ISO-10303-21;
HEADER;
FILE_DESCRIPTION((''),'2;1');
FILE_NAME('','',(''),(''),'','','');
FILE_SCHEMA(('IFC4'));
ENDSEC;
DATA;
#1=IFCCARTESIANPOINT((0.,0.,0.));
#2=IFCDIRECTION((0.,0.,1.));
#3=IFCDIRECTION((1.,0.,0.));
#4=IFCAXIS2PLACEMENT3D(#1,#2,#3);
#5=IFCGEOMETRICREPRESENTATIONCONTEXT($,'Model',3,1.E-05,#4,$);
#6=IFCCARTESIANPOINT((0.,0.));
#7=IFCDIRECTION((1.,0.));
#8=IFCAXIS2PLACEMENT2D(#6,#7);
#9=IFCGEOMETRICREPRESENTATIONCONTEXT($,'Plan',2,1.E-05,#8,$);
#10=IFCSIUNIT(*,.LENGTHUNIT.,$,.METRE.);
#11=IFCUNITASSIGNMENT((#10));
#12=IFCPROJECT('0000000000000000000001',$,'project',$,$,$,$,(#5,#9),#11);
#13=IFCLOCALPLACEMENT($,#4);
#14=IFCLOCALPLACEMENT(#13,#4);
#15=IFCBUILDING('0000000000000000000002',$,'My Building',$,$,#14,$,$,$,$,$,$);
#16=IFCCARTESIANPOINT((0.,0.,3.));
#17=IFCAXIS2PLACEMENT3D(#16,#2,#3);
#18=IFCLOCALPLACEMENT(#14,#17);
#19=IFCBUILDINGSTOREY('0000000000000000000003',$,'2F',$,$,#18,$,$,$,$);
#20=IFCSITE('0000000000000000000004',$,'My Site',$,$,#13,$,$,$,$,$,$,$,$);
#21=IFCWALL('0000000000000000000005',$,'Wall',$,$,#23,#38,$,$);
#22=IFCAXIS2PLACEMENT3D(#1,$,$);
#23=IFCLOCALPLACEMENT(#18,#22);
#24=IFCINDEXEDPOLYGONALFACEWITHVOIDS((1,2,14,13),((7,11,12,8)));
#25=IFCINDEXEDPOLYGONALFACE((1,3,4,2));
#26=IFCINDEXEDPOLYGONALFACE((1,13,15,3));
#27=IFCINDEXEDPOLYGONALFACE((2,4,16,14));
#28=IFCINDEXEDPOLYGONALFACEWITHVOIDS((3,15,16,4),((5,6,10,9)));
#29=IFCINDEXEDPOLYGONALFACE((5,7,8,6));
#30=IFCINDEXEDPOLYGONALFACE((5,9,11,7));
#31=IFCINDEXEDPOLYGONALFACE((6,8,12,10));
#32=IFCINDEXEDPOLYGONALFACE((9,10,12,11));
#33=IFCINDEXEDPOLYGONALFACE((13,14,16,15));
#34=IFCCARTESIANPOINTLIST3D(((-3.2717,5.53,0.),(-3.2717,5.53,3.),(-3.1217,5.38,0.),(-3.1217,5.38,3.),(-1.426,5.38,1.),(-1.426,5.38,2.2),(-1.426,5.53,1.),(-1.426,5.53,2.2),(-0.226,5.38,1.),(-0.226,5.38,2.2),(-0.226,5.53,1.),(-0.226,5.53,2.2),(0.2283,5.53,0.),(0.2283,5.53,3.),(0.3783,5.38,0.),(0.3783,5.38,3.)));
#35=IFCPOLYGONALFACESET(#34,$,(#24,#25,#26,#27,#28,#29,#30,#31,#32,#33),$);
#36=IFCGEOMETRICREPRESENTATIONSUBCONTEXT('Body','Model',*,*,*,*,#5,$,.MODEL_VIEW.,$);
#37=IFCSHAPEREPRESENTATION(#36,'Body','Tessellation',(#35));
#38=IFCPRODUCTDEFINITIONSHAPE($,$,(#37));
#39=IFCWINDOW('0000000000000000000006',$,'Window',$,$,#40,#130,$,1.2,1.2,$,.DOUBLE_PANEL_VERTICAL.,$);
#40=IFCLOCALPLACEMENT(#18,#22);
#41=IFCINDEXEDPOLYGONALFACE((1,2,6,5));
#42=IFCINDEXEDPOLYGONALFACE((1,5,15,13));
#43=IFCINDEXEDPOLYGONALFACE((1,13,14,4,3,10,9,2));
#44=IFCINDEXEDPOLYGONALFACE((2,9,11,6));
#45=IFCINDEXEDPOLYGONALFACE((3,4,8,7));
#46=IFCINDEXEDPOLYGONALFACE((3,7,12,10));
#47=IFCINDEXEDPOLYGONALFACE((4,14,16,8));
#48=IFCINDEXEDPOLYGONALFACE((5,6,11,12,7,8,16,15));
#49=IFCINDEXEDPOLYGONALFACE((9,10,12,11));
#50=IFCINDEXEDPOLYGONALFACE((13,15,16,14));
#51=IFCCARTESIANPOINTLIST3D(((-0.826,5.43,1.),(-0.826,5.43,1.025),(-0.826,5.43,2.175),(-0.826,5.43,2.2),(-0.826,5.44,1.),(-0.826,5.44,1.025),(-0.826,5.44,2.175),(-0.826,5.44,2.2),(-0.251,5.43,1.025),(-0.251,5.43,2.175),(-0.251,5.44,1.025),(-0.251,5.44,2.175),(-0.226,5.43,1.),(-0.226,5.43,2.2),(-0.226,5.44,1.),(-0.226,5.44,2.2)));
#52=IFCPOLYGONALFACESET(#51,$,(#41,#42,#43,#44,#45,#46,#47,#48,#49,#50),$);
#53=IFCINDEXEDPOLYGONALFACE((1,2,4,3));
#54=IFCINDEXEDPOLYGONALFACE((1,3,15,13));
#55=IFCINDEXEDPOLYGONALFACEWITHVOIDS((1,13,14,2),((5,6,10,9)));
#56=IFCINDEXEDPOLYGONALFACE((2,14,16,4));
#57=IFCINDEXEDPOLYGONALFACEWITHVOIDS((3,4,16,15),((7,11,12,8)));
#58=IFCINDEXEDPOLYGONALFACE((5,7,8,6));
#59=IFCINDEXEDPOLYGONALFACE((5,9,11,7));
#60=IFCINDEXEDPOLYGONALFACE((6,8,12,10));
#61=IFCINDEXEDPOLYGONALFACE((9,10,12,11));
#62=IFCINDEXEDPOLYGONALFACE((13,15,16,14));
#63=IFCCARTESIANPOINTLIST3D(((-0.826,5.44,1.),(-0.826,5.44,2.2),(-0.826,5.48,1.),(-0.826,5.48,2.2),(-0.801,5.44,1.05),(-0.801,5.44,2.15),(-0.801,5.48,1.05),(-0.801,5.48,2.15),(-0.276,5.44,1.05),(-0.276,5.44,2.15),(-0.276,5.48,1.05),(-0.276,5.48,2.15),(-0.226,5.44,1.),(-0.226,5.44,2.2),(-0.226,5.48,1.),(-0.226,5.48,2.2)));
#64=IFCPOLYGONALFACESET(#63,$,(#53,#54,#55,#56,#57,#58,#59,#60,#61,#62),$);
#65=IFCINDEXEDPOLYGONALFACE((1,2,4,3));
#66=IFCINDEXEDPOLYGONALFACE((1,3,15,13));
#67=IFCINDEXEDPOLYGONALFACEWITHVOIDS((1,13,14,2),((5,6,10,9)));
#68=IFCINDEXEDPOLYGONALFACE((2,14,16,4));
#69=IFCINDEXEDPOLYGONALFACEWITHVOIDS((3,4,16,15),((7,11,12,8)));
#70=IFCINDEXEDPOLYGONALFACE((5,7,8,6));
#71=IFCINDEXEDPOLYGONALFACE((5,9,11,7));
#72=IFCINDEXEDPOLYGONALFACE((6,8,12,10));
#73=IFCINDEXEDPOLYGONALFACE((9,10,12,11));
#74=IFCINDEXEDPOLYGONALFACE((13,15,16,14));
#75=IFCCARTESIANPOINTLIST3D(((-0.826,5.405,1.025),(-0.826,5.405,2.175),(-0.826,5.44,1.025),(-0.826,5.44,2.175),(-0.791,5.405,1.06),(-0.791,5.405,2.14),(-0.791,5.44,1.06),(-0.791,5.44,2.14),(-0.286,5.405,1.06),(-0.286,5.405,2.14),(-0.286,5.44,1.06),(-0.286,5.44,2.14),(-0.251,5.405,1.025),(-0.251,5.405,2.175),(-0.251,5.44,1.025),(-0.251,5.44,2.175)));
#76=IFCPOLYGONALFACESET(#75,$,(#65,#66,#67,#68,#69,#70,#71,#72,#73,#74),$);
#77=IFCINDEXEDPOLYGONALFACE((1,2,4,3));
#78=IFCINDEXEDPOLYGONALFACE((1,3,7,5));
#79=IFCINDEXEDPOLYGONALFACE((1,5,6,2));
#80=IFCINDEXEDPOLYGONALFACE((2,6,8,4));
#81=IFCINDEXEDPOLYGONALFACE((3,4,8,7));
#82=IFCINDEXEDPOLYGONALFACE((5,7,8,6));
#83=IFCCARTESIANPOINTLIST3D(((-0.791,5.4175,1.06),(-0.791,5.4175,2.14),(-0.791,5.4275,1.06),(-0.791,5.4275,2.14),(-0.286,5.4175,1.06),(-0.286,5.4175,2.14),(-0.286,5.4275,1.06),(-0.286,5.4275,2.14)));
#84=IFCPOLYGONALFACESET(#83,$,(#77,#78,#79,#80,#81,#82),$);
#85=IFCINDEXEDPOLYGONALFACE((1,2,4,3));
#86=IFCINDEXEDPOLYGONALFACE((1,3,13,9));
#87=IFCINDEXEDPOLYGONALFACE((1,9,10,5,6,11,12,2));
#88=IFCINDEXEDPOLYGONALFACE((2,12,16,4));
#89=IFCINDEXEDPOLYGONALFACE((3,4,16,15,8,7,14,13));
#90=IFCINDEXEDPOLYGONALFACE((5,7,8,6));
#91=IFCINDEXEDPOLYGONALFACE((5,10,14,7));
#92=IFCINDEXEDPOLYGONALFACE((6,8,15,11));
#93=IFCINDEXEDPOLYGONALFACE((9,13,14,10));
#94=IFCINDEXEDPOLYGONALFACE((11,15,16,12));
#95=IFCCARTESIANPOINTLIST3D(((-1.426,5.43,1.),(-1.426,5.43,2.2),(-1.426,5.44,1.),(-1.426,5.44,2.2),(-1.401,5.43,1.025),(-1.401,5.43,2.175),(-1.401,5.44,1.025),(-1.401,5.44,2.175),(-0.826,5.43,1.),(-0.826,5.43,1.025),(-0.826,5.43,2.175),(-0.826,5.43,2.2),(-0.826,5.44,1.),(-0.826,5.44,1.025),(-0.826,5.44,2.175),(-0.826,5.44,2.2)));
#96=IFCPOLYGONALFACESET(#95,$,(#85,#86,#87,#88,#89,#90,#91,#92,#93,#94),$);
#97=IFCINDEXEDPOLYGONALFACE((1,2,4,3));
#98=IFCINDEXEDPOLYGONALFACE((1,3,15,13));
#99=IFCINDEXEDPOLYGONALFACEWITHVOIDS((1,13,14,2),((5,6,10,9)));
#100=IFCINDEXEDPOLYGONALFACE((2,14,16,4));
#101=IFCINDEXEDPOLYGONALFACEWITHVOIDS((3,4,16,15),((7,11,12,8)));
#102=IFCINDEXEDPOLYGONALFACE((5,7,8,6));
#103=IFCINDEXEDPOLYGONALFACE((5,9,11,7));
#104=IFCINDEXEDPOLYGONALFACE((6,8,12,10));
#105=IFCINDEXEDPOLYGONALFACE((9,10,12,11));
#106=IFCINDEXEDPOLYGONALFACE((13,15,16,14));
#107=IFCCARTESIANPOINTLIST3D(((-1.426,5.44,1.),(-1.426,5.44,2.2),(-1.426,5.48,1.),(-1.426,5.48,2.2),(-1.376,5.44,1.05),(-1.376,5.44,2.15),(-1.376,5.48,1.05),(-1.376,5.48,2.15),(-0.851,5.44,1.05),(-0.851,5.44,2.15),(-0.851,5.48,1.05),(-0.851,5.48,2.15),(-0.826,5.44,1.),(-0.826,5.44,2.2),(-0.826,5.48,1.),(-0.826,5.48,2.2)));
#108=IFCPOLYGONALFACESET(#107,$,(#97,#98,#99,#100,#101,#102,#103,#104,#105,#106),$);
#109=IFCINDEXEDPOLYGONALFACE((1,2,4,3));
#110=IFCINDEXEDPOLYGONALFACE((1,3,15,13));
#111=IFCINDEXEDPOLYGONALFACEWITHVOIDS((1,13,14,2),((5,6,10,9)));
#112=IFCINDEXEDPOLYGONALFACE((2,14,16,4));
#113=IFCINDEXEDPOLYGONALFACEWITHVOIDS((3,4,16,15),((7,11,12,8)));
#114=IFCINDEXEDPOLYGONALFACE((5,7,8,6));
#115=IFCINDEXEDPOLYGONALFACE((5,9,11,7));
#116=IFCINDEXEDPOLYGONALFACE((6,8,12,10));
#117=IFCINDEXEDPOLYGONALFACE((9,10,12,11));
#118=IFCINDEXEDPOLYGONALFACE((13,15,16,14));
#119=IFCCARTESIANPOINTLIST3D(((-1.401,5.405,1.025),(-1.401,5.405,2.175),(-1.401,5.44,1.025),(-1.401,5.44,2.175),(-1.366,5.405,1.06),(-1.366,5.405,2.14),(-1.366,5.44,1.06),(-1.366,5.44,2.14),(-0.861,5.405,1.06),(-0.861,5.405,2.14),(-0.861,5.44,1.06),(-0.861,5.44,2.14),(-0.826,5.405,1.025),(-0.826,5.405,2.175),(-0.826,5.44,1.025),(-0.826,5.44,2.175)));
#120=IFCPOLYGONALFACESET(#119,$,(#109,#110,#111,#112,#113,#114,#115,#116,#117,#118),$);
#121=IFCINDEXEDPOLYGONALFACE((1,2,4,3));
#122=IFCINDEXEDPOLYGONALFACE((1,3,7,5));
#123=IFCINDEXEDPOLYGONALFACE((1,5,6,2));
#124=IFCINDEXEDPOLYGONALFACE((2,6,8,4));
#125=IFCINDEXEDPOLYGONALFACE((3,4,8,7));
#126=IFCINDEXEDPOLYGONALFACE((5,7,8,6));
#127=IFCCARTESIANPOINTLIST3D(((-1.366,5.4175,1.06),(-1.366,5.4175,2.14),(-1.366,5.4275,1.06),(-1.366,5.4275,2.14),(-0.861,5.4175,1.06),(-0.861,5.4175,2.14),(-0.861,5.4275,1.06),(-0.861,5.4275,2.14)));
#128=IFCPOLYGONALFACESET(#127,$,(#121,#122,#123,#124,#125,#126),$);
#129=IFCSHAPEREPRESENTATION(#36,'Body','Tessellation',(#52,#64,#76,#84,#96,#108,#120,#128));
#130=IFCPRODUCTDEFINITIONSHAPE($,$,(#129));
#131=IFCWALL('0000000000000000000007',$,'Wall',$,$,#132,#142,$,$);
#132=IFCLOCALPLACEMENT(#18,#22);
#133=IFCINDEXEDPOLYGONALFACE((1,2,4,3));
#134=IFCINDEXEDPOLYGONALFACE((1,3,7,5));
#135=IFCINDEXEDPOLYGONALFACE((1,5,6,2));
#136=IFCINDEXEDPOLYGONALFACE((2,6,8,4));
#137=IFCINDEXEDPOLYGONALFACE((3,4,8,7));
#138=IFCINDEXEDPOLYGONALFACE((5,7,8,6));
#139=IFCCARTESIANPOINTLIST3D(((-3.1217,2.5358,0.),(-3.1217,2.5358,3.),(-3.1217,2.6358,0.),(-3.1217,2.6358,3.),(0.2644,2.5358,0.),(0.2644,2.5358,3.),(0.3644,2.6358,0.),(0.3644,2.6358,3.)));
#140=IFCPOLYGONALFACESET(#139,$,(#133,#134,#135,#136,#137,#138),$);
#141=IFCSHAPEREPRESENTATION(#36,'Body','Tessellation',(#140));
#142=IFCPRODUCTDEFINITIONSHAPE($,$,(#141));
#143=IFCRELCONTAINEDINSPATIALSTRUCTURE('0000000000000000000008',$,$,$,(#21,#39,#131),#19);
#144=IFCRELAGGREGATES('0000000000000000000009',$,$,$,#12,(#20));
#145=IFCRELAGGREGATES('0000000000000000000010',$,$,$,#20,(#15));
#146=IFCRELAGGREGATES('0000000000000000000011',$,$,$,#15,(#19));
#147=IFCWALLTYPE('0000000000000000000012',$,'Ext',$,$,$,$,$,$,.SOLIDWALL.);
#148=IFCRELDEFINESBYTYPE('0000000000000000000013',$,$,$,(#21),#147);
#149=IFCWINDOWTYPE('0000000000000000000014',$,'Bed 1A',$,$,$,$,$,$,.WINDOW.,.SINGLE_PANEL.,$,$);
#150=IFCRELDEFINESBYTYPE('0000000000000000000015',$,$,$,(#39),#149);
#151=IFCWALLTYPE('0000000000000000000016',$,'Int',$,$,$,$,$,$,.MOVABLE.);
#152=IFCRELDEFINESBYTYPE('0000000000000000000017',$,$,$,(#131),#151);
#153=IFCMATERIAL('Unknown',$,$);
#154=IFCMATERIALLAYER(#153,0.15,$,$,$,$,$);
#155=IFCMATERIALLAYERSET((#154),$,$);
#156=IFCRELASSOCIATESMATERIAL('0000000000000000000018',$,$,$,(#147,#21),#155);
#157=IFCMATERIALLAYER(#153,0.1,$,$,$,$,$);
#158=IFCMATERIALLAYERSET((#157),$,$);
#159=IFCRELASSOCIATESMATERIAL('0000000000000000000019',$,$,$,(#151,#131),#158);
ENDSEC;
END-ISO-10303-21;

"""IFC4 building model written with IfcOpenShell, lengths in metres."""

from ifc_helpers import new_model, entity, si_unit, frame, origin_with_axes, origin_2d_with_axis, place, context, subcontext, project, spatial, line, indexed_curve, outline, extrude, shape, source, transform, mapped, material, layer, layer_set, layer_usage, type_object, type_shapes, element, fill, save


model = new_model("IFC4")

# Units and contexts
model_context = context("Model", 3, precision=1e-05, world=origin_with_axes())
plan_context = context("Plan", 2, precision=1e-05, world=origin_2d_with_axis())
body_context_1 = subcontext(model_context, "Body", "Model", "MODEL_VIEW")
body_context_2 = subcontext(plan_context, "Body", "Plan", "PLAN_VIEW")
ifc_project = project(units=[si_unit("LENGTHUNIT", "METRE")], contexts=[model_context, plan_context])

# Site, building, storey
site_placement = place(None, origin_with_axes())
site = spatial("IfcSite", under=ifc_project, at=site_placement, Name="My Site")
building_placement = place(site_placement, origin_with_axes())
building = spatial("IfcBuilding", under=site, at=building_placement, Name="My Building")
storey_placement = place(building_placement, frame((0.0, 0.0, 3.0), z_axis=(0.0, 0.0, 1.0), x_axis=(1.0, 0.0, 0.0)))
storey = spatial("IfcBuildingStorey", under=building, at=storey_placement, Name="2F")

# Shared definitions
ifc_material = material(Name="Unknown")

# Shared definitions
ifc_layer_1 = layer(ifc_material, 0.15)
ifc_layer_set_1 = layer_set([ifc_layer_1])
wall_type_1 = type_object("IfcWallType", Name="Ext", PredefinedType="SOLIDWALL", material=ifc_layer_set_1)

# Wall, opening, window
ifc_layer_usage_1 = layer_usage(ifc_layer_set_1, "AXIS2", "POSITIVE", 0.0)
wall_1_placement = place(storey_placement, frame((0.2283, 5.53, 0.0), z_axis=(0.0, 0.0, 1.0), x_axis=(-1.0, 0.0, 0.0)))
wall_1 = element("IfcWall", 1, at=wall_1_placement, inside=storey, type_object=wall_type_1, material=ifc_layer_usage_1, Name="Wall", context=body_context_1, shape_type="SweptSolid", body=[
    extrude(outline(indexed_curve([(0.0, 0.0), (-0.15, 0.15), (3.35, 0.15), (3.5, 0.0)], segments=[line(1, 2, 3, 4, 1)])), origin_with_axes(), (0.0, 0.0, 1.0), 3.0),
])
shared_shape_1 = source(origin_with_axes(), body_context_1, "Body", "SweptSolid", [
    extrude(outline(indexed_curve([(0.0, 0.0), (1.2, 0.0), (1.2, 1.2), (0.0, 1.2)], segments=[line(1, 2, 3, 4, 1)])), frame((0.0, -0.6, 0.0), z_axis=(0.0, -1.0, 0.0), x_axis=(1.0, 0.0, 0.0)), (0.0, 0.0, -1.0), 1.2),
])
opening_1_placement = place(wall_1_placement, frame((0.4544, 0.0, 1.0), z_axis=(0.0, 0.0, 1.0), x_axis=(1.0, 0.0, 0.0)))
opening_1 = element("IfcOpeningElement", 2, at=opening_1_placement, cuts=wall_1, PredefinedType="OPENING", context=body_context_1, shape_type="MappedRepresentation", body=[
    mapped(shared_shape_1, transform((0.0, 0.0, 0.0), x_axis=(1.0, 0.0, 0.0), y_axis=(0.0, 1.0, 0.0), z_axis=(0.0, 0.0, 1.0), scale=1.0)),
])
window_type_1 = type_object("IfcWindowType", Name="Bed 1A", PartitioningType="SINGLE_PANEL", PredefinedType="WINDOW")
shared_shape_2 = source(origin_with_axes(), body_context_1, "Body", "SweptSolid", [
    extrude(outline(indexed_curve([(0.6, 0.0), (0.0, 0.0), (0.0, 1.2), (0.6, 1.2), (0.6, 1.175), (0.025, 1.175), (0.025, 0.025), (0.6, 0.025)], segments=[line(1, 2, 3, 4, 5, 6, 7, 8, 1)])), frame((0.0, 0.09, 0.0), z_axis=(0.0, -1.0, 0.0), x_axis=(1.0, 0.0, 0.0)), (0.0, 0.0, -1.0), 0.01),
    extrude(outline(indexed_curve([(0.0, 0.0), (0.6, 0.0), (0.6, 1.2), (0.0, 1.2)], segments=[line(1, 2, 3, 4, 1)]), holes=[indexed_curve([(0.05, 0.05), (0.575, 0.05), (0.575, 1.15), (0.05, 1.15)], segments=[line(1, 2, 3, 4, 1)])]), frame((0.0, 0.05, 0.0), z_axis=(0.0, -1.0, 0.0), x_axis=(1.0, 0.0, 0.0)), (0.0, 0.0, -1.0), 0.04),
    extrude(outline(indexed_curve([(0.0, 1.15), (0.575, 1.15), (0.575, 0.0), (0.0, 0.0), (0.0, 1.15)]), holes=[indexed_curve([(0.035, 1.115), (0.54, 1.115), (0.54, 0.035), (0.035, 0.035), (0.035, 1.115)])]), frame((0.025, 0.09, 0.025), z_axis=(0.0, -1.0, 0.0), x_axis=(1.0, 0.0, 0.0)), (0.0, 0.0, -1.0), 0.035),
    extrude(outline(indexed_curve([(0.035, 0.035), (0.54, 0.035), (0.54, 1.115), (0.035, 1.115)], segments=[line(1, 2, 3, 4, 1)])), frame((0.025, 0.1025, 0.025), z_axis=(0.0, -1.0, 0.0), x_axis=(1.0, 0.0, 0.0)), (0.0, 0.0, -1.0), 0.01),
    extrude(outline(indexed_curve([(0.0, 1.2), (0.6, 1.2), (0.6, 0.0), (0.0, 0.0), (0.0, 0.025), (0.575, 0.025), (0.575, 1.175), (0.0, 1.175)], segments=[line(1, 2, 3, 4, 5, 6, 7, 8, 1)])), frame((0.6, 0.09, 0.0), z_axis=(0.0, -1.0, 0.0), x_axis=(1.0, 0.0, 0.0)), (0.0, 0.0, -1.0), 0.01),
    extrude(outline(indexed_curve([(0.0, 0.0), (0.6, 0.0), (0.6, 1.2), (0.0, 1.2)], segments=[line(1, 2, 3, 4, 1)]), holes=[indexed_curve([(0.025, 0.05), (0.55, 0.05), (0.55, 1.15), (0.025, 1.15)], segments=[line(1, 2, 3, 4, 1)])]), frame((0.6, 0.05, 0.0), z_axis=(0.0, -1.0, 0.0), x_axis=(1.0, 0.0, 0.0)), (0.0, 0.0, -1.0), 0.04),
    extrude(outline(indexed_curve([(0.0, 0.0), (0.575, 0.0), (0.575, 1.15), (0.0, 1.15)], segments=[line(1, 2, 3, 4, 1)]), holes=[indexed_curve([(0.035, 0.035), (0.54, 0.035), (0.54, 1.115), (0.035, 1.115)], segments=[line(1, 2, 3, 4, 1)])]), frame((0.6, 0.09, 0.025), z_axis=(0.0, -1.0, 0.0), x_axis=(1.0, 0.0, 0.0)), (0.0, 0.0, -1.0), 0.035),
    extrude(outline(indexed_curve([(0.035, 0.035), (0.54, 0.035), (0.54, 1.115), (0.035, 1.115)], segments=[line(1, 2, 3, 4, 1)])), frame((0.6, 0.1025, 0.025), z_axis=(0.0, -1.0, 0.0), x_axis=(1.0, 0.0, 0.0)), (0.0, 0.0, -1.0), 0.01),
])
shared_shape_3 = source(origin_with_axes(), body_context_2, "Body", "Curve2D", [
    entity("IfcIndexedPolyCurve", entity("IfcCartesianPointList2D", [[0.05, 0.05], [0.575, 0.05]])),
    entity("IfcIndexedPolyCurve", entity("IfcCartesianPointList2D", [[0.0, 0.1], [0.025, 0.1], [0.025, 0.09], [0.05, 0.09], [0.05, 0.05], [0.0, 0.05]]), [entity("IfcLineIndex", [1, 2, 3, 4, 5, 6, 1])]),
    entity("IfcIndexedPolyCurve", entity("IfcCartesianPointList2D", [[0.6, 0.1], [0.6, 0.1], [0.6, 0.09], [0.575, 0.09], [0.575, 0.05], [0.6, 0.05]])),
    entity("IfcIndexedPolyCurve", entity("IfcCartesianPointList2D", [[0.025, 0.09], [0.06, 0.09], [0.06, 0.125], [0.025, 0.125]]), [entity("IfcLineIndex", [1, 2, 3, 4, 1])]),
    entity("IfcIndexedPolyCurve", entity("IfcCartesianPointList2D", [[0.6, 0.09], [0.565, 0.09], [0.565, 0.125], [0.6, 0.125]]), [entity("IfcLineIndex", [1, 2, 3, 4, 1])]),
    entity("IfcIndexedPolyCurve", entity("IfcCartesianPointList2D", [[0.06, 0.09], [0.565, 0.09]])),
    entity("IfcIndexedPolyCurve", entity("IfcCartesianPointList2D", [[0.06, 0.125], [0.565, 0.125]])),
    entity("IfcIndexedPolyCurve", entity("IfcCartesianPointList2D", [[0.06, 0.1075], [0.565, 0.1075]])),
    entity("IfcIndexedPolyCurve", entity("IfcCartesianPointList2D", [[0.625, 0.05], [1.15, 0.05]])),
    entity("IfcIndexedPolyCurve", entity("IfcCartesianPointList2D", [[0.6, 0.1], [0.6, 0.1], [0.6, 0.09], [0.625, 0.09], [0.625, 0.05], [0.6, 0.05]])),
    entity("IfcIndexedPolyCurve", entity("IfcCartesianPointList2D", [[1.2, 0.1], [1.175, 0.1], [1.175, 0.09], [1.15, 0.09], [1.15, 0.05], [1.2, 0.05]]), [entity("IfcLineIndex", [1, 2, 3, 4, 5, 6, 1])]),
    entity("IfcIndexedPolyCurve", entity("IfcCartesianPointList2D", [[0.6, 0.09], [0.635, 0.09], [0.635, 0.125], [0.6, 0.125]]), [entity("IfcLineIndex", [1, 2, 3, 4, 1])]),
    entity("IfcIndexedPolyCurve", entity("IfcCartesianPointList2D", [[1.175, 0.09], [1.14, 0.09], [1.14, 0.125], [1.175, 0.125]]), [entity("IfcLineIndex", [1, 2, 3, 4, 1])]),
    entity("IfcIndexedPolyCurve", entity("IfcCartesianPointList2D", [[0.635, 0.09], [1.14, 0.09]])),
    entity("IfcIndexedPolyCurve", entity("IfcCartesianPointList2D", [[0.635, 0.125], [1.14, 0.125]])),
    entity("IfcIndexedPolyCurve", entity("IfcCartesianPointList2D", [[0.635, 0.1075], [1.14, 0.1075]])),
])
type_shapes(window_type_1, [shared_shape_2, shared_shape_3])
window_1_placement = place(opening_1_placement, frame((0.0, 0.0, 0.0), z_axis=(0.0, 0.0, 1.0), x_axis=(1.0, 0.0, 0.0)))
window_1 = element("IfcWindow", 3, at=window_1_placement, inside=storey, type_object=window_type_1, Name="Window", OverallHeight=1.2, OverallWidth=1.2, PartitioningType="DOUBLE_PANEL_VERTICAL", shapes=[
    shape(body_context_1, "Body", "MappedRepresentation", [mapped(shared_shape_2, transform((0.0, 0.0, 0.0), x_axis=(1.0, 0.0, 0.0), y_axis=(0.0, 1.0, 0.0), z_axis=(0.0, 0.0, 1.0), scale=1.0))]),
    shape(body_context_2, "Body", "MappedRepresentation", [mapped(shared_shape_3, transform((0.0, 0.0, 0.0), x_axis=(1.0, 0.0, 0.0), y_axis=(0.0, 1.0, 0.0), z_axis=(0.0, 0.0, 1.0), scale=1.0))]),
])
fill(opening_1, window_1)

# Wall
ifc_layer_2 = layer(ifc_material, 0.1)
ifc_layer_set_2 = layer_set([ifc_layer_2])
ifc_layer_usage_2 = layer_usage(ifc_layer_set_2, "AXIS2", "POSITIVE", 0.0)
wall_type_2 = type_object("IfcWallType", Name="Int", PredefinedType="MOVABLE", material=ifc_layer_set_2)
wall_2_placement = place(storey_placement, frame((-3.1217, 2.5358, 0.0), z_axis=(0.0, 0.0, 1.0), x_axis=(1.0, 0.0, 0.0)))
element("IfcWall", 4, at=wall_2_placement, inside=storey, type_object=wall_type_2, material=ifc_layer_usage_2, Name="Wall", context=body_context_1, shape_type="SweptSolid", body=[
    extrude(outline(indexed_curve([(0.0, 0.0), (0.0, 0.1), (3.4861, 0.1), (3.3861, 0.0)], segments=[line(1, 2, 3, 4, 1)])), origin_with_axes(), (0.0, 0.0, 1.0), 3.0),
])

save(model, "model.ifc")
